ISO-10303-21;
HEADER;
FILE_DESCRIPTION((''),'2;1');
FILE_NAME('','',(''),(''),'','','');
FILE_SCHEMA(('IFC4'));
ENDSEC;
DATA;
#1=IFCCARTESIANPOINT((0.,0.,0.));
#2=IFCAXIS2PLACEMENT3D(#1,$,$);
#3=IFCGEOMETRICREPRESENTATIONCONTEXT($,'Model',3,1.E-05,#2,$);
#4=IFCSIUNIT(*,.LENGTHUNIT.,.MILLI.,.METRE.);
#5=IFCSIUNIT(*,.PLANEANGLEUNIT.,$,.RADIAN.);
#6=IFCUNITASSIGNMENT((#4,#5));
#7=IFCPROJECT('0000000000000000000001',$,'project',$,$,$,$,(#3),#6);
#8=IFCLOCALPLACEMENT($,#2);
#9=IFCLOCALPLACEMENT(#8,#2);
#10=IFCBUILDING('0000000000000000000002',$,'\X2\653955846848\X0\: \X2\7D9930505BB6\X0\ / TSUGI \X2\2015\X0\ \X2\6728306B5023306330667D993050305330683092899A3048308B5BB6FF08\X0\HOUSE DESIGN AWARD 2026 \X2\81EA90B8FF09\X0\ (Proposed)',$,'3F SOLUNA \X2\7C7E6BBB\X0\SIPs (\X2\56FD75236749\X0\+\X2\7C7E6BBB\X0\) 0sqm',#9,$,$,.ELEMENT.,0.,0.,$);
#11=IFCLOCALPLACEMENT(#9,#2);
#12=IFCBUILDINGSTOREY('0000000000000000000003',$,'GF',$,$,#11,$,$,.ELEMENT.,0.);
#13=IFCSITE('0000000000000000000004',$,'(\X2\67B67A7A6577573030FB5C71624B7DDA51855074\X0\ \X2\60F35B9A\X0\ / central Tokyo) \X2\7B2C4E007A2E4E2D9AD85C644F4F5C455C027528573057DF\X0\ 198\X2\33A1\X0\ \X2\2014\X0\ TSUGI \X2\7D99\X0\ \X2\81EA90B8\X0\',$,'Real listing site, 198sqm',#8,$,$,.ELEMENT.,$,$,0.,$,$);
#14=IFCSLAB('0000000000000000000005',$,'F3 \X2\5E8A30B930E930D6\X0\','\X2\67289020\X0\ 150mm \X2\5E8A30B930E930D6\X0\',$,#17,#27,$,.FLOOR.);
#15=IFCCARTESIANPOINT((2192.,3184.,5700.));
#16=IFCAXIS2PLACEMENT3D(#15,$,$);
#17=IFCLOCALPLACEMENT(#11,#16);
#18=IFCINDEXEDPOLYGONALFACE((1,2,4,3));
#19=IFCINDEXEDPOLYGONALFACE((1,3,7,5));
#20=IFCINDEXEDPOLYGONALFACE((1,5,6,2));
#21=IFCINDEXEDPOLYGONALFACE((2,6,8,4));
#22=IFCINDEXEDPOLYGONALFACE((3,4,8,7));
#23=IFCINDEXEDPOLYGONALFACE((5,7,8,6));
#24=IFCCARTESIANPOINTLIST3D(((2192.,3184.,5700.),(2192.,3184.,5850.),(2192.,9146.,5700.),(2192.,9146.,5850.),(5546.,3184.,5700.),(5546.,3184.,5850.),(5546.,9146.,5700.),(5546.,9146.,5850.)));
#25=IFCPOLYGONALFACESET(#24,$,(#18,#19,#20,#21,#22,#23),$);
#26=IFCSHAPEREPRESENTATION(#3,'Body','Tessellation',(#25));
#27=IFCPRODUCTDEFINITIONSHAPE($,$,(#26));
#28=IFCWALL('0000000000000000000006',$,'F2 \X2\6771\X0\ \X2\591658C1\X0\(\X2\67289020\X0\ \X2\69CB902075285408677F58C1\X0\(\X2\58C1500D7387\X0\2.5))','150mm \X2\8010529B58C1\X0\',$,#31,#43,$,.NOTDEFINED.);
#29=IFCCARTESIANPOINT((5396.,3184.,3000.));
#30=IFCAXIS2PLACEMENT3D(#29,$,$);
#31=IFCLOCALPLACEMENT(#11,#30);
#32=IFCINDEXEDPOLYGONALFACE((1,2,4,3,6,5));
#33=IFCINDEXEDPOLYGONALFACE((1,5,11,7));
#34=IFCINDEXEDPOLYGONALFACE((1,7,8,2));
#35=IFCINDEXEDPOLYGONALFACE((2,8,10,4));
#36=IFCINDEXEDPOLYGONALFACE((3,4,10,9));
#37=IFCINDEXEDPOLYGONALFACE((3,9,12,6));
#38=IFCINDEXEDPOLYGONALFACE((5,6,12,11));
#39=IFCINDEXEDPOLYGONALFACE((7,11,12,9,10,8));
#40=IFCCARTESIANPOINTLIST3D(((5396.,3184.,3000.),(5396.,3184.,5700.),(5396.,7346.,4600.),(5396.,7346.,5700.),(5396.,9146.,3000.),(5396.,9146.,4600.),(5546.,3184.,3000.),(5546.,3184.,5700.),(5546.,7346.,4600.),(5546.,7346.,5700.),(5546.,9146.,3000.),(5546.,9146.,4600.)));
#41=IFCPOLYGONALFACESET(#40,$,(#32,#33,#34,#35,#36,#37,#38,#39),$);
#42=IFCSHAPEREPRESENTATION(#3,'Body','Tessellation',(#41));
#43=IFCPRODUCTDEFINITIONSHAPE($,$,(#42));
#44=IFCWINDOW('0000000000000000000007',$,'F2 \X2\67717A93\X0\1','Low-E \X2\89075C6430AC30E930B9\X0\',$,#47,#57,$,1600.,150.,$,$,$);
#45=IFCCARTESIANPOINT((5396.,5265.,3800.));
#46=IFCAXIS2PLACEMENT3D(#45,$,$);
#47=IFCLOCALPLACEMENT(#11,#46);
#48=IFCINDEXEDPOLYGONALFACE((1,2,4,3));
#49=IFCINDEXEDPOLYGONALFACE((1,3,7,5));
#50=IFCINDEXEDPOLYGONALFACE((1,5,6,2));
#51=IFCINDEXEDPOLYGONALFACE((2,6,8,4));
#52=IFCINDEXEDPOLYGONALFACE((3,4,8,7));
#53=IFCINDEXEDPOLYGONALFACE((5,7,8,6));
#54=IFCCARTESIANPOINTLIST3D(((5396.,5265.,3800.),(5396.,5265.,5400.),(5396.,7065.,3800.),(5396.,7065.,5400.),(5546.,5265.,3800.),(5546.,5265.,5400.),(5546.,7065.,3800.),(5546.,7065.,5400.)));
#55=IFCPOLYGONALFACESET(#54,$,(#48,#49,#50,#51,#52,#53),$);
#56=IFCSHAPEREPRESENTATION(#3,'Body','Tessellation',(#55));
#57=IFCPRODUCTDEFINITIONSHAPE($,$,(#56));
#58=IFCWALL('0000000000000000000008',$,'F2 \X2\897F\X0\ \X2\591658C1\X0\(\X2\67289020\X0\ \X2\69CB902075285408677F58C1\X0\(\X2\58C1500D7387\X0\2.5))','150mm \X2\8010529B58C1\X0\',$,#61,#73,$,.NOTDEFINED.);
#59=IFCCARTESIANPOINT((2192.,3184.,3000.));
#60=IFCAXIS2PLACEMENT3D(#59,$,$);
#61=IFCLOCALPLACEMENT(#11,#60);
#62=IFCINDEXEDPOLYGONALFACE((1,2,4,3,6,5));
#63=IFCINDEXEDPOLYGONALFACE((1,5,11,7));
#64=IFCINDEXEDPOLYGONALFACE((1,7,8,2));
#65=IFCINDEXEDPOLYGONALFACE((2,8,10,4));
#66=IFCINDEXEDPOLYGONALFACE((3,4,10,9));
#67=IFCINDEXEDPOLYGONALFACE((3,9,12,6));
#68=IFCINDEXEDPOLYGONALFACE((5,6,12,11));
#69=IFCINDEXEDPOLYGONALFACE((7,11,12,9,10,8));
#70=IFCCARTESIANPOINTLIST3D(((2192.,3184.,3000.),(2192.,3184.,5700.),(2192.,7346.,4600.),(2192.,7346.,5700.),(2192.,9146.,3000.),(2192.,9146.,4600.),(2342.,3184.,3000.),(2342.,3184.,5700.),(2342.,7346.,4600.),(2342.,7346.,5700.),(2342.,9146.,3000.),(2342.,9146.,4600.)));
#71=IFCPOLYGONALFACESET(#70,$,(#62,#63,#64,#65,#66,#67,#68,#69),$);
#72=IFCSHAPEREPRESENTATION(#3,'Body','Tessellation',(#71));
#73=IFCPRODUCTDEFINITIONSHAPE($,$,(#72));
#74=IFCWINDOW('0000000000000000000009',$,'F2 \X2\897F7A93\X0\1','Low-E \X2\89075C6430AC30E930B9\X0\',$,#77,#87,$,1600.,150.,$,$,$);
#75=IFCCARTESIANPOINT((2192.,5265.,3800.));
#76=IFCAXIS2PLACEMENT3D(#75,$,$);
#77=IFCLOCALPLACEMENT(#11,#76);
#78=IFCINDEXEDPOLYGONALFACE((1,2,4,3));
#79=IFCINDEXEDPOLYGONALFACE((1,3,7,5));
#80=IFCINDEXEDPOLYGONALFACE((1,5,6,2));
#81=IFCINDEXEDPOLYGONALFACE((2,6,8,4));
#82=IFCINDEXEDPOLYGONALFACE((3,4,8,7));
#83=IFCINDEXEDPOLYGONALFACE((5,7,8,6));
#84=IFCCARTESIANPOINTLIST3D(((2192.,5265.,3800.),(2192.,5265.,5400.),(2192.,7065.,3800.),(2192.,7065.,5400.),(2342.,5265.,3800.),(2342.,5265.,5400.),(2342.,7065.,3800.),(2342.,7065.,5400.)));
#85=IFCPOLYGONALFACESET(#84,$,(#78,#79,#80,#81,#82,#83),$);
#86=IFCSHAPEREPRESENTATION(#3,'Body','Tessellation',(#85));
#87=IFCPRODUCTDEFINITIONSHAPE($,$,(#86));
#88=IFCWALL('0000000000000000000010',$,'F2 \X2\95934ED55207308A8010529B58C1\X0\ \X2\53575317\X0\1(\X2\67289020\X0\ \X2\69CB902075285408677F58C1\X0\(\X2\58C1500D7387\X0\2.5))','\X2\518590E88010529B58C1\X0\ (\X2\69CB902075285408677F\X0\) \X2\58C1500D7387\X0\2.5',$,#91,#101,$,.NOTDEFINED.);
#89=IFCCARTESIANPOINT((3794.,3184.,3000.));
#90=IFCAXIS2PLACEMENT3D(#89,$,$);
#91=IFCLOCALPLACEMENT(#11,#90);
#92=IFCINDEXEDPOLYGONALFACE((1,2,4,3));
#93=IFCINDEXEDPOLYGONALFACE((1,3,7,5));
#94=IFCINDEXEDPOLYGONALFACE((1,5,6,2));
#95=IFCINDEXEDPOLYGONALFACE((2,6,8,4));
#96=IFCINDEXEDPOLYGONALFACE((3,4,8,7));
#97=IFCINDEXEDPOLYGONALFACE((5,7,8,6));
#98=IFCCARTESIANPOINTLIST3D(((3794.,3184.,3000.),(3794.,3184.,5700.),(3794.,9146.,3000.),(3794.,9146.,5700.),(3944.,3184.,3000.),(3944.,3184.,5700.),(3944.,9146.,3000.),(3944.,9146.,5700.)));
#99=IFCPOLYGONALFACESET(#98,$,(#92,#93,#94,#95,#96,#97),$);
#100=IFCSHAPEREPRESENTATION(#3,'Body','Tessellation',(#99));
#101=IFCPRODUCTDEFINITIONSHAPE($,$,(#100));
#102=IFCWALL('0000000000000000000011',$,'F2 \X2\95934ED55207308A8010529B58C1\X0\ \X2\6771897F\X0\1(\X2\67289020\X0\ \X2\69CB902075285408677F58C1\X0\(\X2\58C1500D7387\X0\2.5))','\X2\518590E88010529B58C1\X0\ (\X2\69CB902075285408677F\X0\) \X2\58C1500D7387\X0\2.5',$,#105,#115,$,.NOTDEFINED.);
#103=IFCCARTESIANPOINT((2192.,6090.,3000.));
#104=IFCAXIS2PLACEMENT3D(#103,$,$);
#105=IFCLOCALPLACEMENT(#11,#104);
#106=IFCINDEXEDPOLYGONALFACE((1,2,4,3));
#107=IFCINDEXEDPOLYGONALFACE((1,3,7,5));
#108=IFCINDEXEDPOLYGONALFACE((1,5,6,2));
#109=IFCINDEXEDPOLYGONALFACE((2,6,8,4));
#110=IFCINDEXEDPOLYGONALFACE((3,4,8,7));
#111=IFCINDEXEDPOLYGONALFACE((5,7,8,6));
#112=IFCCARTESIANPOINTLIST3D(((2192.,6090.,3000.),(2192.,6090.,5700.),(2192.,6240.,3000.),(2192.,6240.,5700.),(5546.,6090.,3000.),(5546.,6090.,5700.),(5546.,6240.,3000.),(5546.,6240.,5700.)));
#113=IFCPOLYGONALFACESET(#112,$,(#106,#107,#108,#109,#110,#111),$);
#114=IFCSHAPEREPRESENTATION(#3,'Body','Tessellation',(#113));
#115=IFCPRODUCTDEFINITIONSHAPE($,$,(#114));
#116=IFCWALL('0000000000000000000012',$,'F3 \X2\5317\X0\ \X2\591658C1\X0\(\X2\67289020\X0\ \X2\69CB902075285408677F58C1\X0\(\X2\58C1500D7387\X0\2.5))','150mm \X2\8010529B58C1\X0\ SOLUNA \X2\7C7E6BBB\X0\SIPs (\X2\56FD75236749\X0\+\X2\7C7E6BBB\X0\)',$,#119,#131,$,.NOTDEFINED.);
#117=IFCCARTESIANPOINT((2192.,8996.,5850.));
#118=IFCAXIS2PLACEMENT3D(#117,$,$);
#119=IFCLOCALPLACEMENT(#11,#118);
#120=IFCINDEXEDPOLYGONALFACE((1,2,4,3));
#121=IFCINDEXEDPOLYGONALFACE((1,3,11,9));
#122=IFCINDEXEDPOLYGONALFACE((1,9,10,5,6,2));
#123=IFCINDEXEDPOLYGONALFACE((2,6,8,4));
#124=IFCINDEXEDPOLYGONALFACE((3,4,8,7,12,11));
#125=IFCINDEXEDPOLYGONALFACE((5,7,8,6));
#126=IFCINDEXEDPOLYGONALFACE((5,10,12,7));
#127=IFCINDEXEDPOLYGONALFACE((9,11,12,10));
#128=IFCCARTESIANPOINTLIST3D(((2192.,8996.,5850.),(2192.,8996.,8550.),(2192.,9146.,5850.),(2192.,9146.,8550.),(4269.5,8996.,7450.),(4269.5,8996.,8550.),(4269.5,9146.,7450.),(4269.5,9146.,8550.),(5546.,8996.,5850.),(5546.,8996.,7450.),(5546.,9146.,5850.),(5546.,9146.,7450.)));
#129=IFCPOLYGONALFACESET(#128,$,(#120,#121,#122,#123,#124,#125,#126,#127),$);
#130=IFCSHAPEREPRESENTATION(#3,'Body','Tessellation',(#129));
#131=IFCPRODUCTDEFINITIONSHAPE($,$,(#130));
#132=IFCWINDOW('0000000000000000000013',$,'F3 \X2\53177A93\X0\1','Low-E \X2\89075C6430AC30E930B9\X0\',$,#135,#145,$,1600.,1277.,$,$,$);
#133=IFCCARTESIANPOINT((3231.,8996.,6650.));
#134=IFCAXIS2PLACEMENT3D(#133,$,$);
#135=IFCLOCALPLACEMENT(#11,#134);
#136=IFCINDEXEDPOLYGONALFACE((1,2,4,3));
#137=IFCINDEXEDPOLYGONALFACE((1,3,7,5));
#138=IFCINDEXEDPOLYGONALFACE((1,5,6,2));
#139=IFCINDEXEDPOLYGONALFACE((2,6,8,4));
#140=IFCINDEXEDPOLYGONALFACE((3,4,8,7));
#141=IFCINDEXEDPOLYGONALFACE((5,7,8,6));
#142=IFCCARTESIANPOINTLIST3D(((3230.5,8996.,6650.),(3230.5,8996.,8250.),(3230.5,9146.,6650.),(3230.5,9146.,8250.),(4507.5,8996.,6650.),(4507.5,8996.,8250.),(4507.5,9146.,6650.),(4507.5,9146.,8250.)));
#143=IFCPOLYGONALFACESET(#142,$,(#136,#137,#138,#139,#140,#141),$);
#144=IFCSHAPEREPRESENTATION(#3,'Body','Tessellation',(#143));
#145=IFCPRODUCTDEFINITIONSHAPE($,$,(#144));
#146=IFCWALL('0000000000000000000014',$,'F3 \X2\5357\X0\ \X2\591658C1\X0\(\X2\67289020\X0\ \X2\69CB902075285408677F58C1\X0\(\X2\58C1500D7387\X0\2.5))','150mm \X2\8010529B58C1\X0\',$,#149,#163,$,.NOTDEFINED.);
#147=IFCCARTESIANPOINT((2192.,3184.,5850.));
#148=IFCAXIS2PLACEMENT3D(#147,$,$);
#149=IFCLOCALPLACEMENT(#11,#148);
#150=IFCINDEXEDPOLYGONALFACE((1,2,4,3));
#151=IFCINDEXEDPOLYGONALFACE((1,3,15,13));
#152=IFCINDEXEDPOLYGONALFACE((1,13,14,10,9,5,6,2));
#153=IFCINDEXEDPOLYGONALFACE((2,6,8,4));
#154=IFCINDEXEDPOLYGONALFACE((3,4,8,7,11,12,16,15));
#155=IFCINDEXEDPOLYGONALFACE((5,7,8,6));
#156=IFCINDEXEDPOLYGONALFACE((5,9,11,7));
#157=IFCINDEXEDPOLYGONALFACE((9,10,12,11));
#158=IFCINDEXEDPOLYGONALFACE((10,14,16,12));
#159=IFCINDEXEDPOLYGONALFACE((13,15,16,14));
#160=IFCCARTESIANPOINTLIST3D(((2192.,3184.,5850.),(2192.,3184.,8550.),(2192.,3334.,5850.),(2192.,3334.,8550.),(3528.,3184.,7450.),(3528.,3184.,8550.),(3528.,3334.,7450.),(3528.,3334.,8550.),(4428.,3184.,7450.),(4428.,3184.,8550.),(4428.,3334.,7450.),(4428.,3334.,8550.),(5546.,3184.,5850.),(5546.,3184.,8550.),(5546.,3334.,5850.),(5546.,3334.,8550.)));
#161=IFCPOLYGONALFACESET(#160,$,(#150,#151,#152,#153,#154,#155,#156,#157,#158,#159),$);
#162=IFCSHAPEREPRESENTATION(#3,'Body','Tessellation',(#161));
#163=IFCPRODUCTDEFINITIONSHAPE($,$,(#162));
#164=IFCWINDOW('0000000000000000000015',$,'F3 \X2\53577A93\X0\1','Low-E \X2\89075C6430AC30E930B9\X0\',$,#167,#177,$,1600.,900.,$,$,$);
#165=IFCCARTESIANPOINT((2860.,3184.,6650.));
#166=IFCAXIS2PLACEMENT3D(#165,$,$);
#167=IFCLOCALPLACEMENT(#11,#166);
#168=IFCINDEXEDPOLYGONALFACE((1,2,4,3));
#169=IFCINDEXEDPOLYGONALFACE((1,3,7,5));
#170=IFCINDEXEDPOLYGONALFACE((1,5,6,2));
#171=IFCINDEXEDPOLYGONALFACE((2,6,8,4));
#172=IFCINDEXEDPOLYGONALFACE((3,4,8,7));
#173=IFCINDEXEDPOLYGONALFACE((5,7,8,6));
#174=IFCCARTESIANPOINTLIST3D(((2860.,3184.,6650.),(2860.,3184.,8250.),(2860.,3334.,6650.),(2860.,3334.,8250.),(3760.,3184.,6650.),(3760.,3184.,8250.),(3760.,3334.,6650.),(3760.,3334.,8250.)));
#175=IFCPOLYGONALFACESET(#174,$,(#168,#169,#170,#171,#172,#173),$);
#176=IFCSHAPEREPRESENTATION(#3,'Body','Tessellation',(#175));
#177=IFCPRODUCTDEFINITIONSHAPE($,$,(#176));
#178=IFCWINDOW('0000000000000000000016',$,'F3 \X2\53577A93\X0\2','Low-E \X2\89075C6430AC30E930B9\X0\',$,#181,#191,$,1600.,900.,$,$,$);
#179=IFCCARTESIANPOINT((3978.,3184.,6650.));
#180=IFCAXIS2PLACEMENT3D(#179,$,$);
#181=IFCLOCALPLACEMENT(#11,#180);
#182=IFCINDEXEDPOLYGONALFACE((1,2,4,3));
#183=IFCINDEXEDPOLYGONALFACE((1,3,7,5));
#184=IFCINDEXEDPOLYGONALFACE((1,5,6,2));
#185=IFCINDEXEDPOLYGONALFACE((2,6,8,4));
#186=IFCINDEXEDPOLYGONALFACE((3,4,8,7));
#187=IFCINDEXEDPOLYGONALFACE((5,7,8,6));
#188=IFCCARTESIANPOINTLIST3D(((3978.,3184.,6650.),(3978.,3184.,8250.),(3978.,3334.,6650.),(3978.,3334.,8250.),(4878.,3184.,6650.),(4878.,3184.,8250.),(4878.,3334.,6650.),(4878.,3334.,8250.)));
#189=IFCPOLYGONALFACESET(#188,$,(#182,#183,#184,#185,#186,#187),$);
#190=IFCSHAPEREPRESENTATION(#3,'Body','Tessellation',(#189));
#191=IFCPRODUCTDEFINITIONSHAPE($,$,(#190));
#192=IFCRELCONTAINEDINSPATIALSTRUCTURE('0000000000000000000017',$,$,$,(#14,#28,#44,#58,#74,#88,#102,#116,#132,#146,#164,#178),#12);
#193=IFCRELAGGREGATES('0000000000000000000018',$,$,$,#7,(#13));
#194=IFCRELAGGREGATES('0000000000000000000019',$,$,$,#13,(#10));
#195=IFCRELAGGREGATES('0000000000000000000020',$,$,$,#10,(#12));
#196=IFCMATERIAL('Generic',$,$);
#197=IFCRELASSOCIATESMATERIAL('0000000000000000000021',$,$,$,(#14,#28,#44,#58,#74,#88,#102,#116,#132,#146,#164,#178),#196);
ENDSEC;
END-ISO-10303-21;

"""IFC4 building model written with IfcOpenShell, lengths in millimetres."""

from ifc_helpers import new_model, si_unit, frame, frame_2d, origin, place, context, project, spatial, rectangle, extrude, material, element, fill, save


model = new_model("IFC4")

# Units and contexts
model_context = context("Model", 3, precision=1e-05, world=origin())
ifc_project = project(units=[si_unit("LENGTHUNIT", "METRE", prefix="MILLI"), si_unit("PLANEANGLEUNIT", "RADIAN")], contexts=[model_context])

# Site, building, storey
site_placement = place(None, origin())
site = spatial("IfcSite", under=ifc_project, at=site_placement, Name="(架空敷地・山手線内側 想定 / central Tokyo) 第一種中高層住居専用地域 198㎡ — TSUGI 継 自邸", ObjectType="Real listing site, 198sqm", CompositionType="ELEMENT", RefElevation=0.0)
building_placement = place(site_placement, origin())
building = spatial("IfcBuilding", under=site, at=building_placement, Name="改善案: 継ぐ家 / TSUGI ― 木に倣って継ぐことを覚える家（HOUSE DESIGN AWARD 2026 自邸） (Proposed)", ObjectType="3F SOLUNA 籾殻SIPs (国産杉+籾殻) 0sqm", CompositionType="ELEMENT", ElevationOfRefHeight=0.0, ElevationOfTerrain=0.0)
storey_placement = place(building_placement, origin())
storey = spatial("IfcBuildingStorey", under=building, at=storey_placement, Name="GF", CompositionType="ELEMENT", Elevation=0.0)

# Slab
ifc_material_1 = material(Name="Generic")
slab_placement = place(storey_placement, frame((2192.0, 3184.0, 5700.0)))
element("IfcSlab", 1, at=slab_placement, inside=storey, material=ifc_material_1, Name="F3 床スラブ", Description="木造 150mm 床スラブ", PredefinedType="FLOOR", context=model_context, shape_type="SweptSolid", body=[
    extrude(rectangle(XDim=3354.0, YDim=5962.0, at=frame_2d((1677.0, 2981.0))), frame((2192.0, 3184.0, 5700.0)), (0.0, 0.0, 1.0), 150.0),
])

# Walls, openings, windows
wall_1_placement = place(storey_placement, frame((5396.0, 3184.0, 3000.0)))
wall_1 = element("IfcWall", 2, at=wall_1_placement, inside=storey, material=ifc_material_1, Name="F2 東 外壁(木造 構造用合板壁(壁倍率2.5))", Description="150mm 耐力壁", PredefinedType="NOTDEFINED", context=model_context, shape_type="SweptSolid", body=[
    extrude(rectangle(XDim=150.0, YDim=5962.0, at=frame_2d((75.0, 2981.0))), frame((5396.0, 3184.0, 3000.0)), (0.0, 0.0, 1.0), 2700.0),
])
opening_1_placement = place(storey_placement, frame((5396.0, 5265.0, 3800.0)))
opening_1 = element("IfcOpeningElement", 3, at=opening_1_placement, cuts=wall_1, PredefinedType="NOTDEFINED", context=model_context, shape_type="SweptSolid", body=[
    extrude(rectangle(XDim=150.0, YDim=1800.0, at=frame_2d((75.0, 900.0))), frame((5396.0, 5265.0, 3800.0)), (0.0, 0.0, 1.0), 1600.0),
])
window_1_placement = place(storey_placement, frame((5396.0, 5265.0, 3800.0)))
window_1 = element("IfcWindow", 4, at=window_1_placement, inside=storey, material=ifc_material_1, Name="F2 東窓1", Description="Low-E 複層ガラス", OverallHeight=1600.0, OverallWidth=150.0, context=model_context, shape_type="SweptSolid", body=[
    extrude(rectangle(XDim=150.0, YDim=1800.0, at=frame_2d((75.0, 900.0))), frame((5396.0, 5265.0, 3800.0)), (0.0, 0.0, 1.0), 1600.0),
])
fill(opening_1, window_1)
wall_2_placement = place(storey_placement, frame((2192.0, 3184.0, 3000.0)))
wall_2 = element("IfcWall", 5, at=wall_2_placement, inside=storey, material=ifc_material_1, Name="F2 西 外壁(木造 構造用合板壁(壁倍率2.5))", Description="150mm 耐力壁", PredefinedType="NOTDEFINED", context=model_context, shape_type="SweptSolid", body=[
    extrude(rectangle(XDim=150.0, YDim=5962.0, at=frame_2d((75.0, 2981.0))), frame((2192.0, 3184.0, 3000.0)), (0.0, 0.0, 1.0), 2700.0),
])
opening_2_placement = place(storey_placement, frame((2192.0, 5265.0, 3800.0)))
opening_2 = element("IfcOpeningElement", 6, at=opening_2_placement, cuts=wall_2, PredefinedType="NOTDEFINED", context=model_context, shape_type="SweptSolid", body=[
    extrude(rectangle(XDim=150.0, YDim=1800.0, at=frame_2d((75.0, 900.0))), frame((2192.0, 5265.0, 3800.0)), (0.0, 0.0, 1.0), 1600.0),
])
window_2_placement = place(storey_placement, frame((2192.0, 5265.0, 3800.0)))
window_2 = element("IfcWindow", 7, at=window_2_placement, inside=storey, material=ifc_material_1, Name="F2 西窓1", Description="Low-E 複層ガラス", OverallHeight=1600.0, OverallWidth=150.0, context=model_context, shape_type="SweptSolid", body=[
    extrude(rectangle(XDim=150.0, YDim=1800.0, at=frame_2d((75.0, 900.0))), frame((2192.0, 5265.0, 3800.0)), (0.0, 0.0, 1.0), 1600.0),
])
fill(opening_2, window_2)

# Walls
wall_3_placement = place(storey_placement, frame((3794.0, 3184.0, 3000.0)))
element("IfcWall", 8, at=wall_3_placement, inside=storey, material=ifc_material_1, Name="F2 間仕切り耐力壁 南北1(木造 構造用合板壁(壁倍率2.5))", Description="内部耐力壁 (構造用合板) 壁倍率2.5", PredefinedType="NOTDEFINED", context=model_context, shape_type="SweptSolid", body=[
    extrude(rectangle(XDim=150.0, YDim=5962.0, at=frame_2d((75.0, 2981.0))), frame((3794.0, 3184.0, 3000.0)), (0.0, 0.0, 1.0), 2700.0),
])
wall_4_placement = place(storey_placement, frame((2192.0, 6090.0, 3000.0)))
element("IfcWall", 9, at=wall_4_placement, inside=storey, material=ifc_material_1, Name="F2 間仕切り耐力壁 東西1(木造 構造用合板壁(壁倍率2.5))", Description="内部耐力壁 (構造用合板) 壁倍率2.5", PredefinedType="NOTDEFINED", context=model_context, shape_type="SweptSolid", body=[
    extrude(rectangle(XDim=3354.0, YDim=150.0, at=frame_2d((1677.0, 75.0))), frame((2192.0, 6090.0, 3000.0)), (0.0, 0.0, 1.0), 2700.0),
])

# Wall, opening, window
wall_5_placement = place(storey_placement, frame((2192.0, 8996.0, 5850.0)))
wall_5 = element("IfcWall", 10, at=wall_5_placement, inside=storey, material=ifc_material_1, Name="F3 北 外壁(木造 構造用合板壁(壁倍率2.5))", Description="150mm 耐力壁 SOLUNA 籾殻SIPs (国産杉+籾殻)", PredefinedType="NOTDEFINED", context=model_context, shape_type="SweptSolid", body=[
    extrude(rectangle(XDim=3354.0, YDim=150.0, at=frame_2d((1677.0, 75.0))), frame((2192.0, 8996.0, 5850.0)), (0.0, 0.0, 1.0), 2700.0),
])
opening_3_placement = place(storey_placement, frame((3231.0, 8996.0, 6650.0)))
opening_3 = element("IfcOpeningElement", 11, at=opening_3_placement, cuts=wall_5, PredefinedType="NOTDEFINED", context=model_context, shape_type="SweptSolid", body=[
    extrude(rectangle(XDim=1277.0, YDim=150.0, at=frame_2d((638.0, 75.0))), frame((3231.0, 8996.0, 6650.0)), (0.0, 0.0, 1.0), 1600.0),
])
window_3_placement = place(storey_placement, frame((3231.0, 8996.0, 6650.0)))
window_3 = element("IfcWindow", 12, at=window_3_placement, inside=storey, material=ifc_material_1, Name="F3 北窓1", Description="Low-E 複層ガラス", OverallHeight=1600.0, OverallWidth=1277.0, context=model_context, shape_type="SweptSolid", body=[
    extrude(rectangle(XDim=1277.0, YDim=150.0, at=frame_2d((638.0, 75.0))), frame((3231.0, 8996.0, 6650.0)), (0.0, 0.0, 1.0), 1600.0),
])
fill(opening_3, window_3)

# Wall, openings, windows
wall_6_placement = place(storey_placement, frame((2192.0, 3184.0, 5850.0)))
wall_6 = element("IfcWall", 13, at=wall_6_placement, inside=storey, material=ifc_material_1, Name="F3 南 外壁(木造 構造用合板壁(壁倍率2.5))", Description="150mm 耐力壁", PredefinedType="NOTDEFINED", context=model_context, shape_type="SweptSolid", body=[
    extrude(rectangle(XDim=3354.0, YDim=150.0, at=frame_2d((1677.0, 75.0))), frame((2192.0, 3184.0, 5850.0)), (0.0, 0.0, 1.0), 2700.0),
])
opening_4_placement = place(storey_placement, frame((2860.0, 3184.0, 6650.0)))
opening_4 = element("IfcOpeningElement", 14, at=opening_4_placement, cuts=wall_6, PredefinedType="NOTDEFINED", context=model_context, shape_type="SweptSolid", body=[
    extrude(rectangle(XDim=900.0, YDim=150.0, at=frame_2d((450.0, 75.0))), frame((2860.0, 3184.0, 6650.0)), (0.0, 0.0, 1.0), 1600.0),
])
opening_5_placement = place(storey_placement, frame((3978.0, 3184.0, 6650.0)))
opening_5 = element("IfcOpeningElement", 15, at=opening_5_placement, cuts=wall_6, PredefinedType="NOTDEFINED", context=model_context, shape_type="SweptSolid", body=[
    extrude(rectangle(XDim=900.0, YDim=150.0, at=frame_2d((450.0, 75.0))), frame((3978.0, 3184.0, 6650.0)), (0.0, 0.0, 1.0), 1600.0),
])
window_4_placement = place(storey_placement, frame((2860.0, 3184.0, 6650.0)))
window_4 = element("IfcWindow", 16, at=window_4_placement, inside=storey, material=ifc_material_1, Name="F3 南窓1", Description="Low-E 複層ガラス", OverallHeight=1600.0, OverallWidth=900.0, context=model_context, shape_type="SweptSolid", body=[
    extrude(rectangle(XDim=900.0, YDim=150.0, at=frame_2d((450.0, 75.0))), frame((2860.0, 3184.0, 6650.0)), (0.0, 0.0, 1.0), 1600.0),
])
fill(opening_4, window_4)
window_5_placement = place(storey_placement, frame((3978.0, 3184.0, 6650.0)))
window_5 = element("IfcWindow", 17, at=window_5_placement, inside=storey, material=ifc_material_1, Name="F3 南窓2", Description="Low-E 複層ガラス", OverallHeight=1600.0, OverallWidth=900.0, context=model_context, shape_type="SweptSolid", body=[
    extrude(rectangle(XDim=900.0, YDim=150.0, at=frame_2d((450.0, 75.0))), frame((3978.0, 3184.0, 6650.0)), (0.0, 0.0, 1.0), 1600.0),
])
fill(opening_5, window_5)

save(model, "model.ifc")
